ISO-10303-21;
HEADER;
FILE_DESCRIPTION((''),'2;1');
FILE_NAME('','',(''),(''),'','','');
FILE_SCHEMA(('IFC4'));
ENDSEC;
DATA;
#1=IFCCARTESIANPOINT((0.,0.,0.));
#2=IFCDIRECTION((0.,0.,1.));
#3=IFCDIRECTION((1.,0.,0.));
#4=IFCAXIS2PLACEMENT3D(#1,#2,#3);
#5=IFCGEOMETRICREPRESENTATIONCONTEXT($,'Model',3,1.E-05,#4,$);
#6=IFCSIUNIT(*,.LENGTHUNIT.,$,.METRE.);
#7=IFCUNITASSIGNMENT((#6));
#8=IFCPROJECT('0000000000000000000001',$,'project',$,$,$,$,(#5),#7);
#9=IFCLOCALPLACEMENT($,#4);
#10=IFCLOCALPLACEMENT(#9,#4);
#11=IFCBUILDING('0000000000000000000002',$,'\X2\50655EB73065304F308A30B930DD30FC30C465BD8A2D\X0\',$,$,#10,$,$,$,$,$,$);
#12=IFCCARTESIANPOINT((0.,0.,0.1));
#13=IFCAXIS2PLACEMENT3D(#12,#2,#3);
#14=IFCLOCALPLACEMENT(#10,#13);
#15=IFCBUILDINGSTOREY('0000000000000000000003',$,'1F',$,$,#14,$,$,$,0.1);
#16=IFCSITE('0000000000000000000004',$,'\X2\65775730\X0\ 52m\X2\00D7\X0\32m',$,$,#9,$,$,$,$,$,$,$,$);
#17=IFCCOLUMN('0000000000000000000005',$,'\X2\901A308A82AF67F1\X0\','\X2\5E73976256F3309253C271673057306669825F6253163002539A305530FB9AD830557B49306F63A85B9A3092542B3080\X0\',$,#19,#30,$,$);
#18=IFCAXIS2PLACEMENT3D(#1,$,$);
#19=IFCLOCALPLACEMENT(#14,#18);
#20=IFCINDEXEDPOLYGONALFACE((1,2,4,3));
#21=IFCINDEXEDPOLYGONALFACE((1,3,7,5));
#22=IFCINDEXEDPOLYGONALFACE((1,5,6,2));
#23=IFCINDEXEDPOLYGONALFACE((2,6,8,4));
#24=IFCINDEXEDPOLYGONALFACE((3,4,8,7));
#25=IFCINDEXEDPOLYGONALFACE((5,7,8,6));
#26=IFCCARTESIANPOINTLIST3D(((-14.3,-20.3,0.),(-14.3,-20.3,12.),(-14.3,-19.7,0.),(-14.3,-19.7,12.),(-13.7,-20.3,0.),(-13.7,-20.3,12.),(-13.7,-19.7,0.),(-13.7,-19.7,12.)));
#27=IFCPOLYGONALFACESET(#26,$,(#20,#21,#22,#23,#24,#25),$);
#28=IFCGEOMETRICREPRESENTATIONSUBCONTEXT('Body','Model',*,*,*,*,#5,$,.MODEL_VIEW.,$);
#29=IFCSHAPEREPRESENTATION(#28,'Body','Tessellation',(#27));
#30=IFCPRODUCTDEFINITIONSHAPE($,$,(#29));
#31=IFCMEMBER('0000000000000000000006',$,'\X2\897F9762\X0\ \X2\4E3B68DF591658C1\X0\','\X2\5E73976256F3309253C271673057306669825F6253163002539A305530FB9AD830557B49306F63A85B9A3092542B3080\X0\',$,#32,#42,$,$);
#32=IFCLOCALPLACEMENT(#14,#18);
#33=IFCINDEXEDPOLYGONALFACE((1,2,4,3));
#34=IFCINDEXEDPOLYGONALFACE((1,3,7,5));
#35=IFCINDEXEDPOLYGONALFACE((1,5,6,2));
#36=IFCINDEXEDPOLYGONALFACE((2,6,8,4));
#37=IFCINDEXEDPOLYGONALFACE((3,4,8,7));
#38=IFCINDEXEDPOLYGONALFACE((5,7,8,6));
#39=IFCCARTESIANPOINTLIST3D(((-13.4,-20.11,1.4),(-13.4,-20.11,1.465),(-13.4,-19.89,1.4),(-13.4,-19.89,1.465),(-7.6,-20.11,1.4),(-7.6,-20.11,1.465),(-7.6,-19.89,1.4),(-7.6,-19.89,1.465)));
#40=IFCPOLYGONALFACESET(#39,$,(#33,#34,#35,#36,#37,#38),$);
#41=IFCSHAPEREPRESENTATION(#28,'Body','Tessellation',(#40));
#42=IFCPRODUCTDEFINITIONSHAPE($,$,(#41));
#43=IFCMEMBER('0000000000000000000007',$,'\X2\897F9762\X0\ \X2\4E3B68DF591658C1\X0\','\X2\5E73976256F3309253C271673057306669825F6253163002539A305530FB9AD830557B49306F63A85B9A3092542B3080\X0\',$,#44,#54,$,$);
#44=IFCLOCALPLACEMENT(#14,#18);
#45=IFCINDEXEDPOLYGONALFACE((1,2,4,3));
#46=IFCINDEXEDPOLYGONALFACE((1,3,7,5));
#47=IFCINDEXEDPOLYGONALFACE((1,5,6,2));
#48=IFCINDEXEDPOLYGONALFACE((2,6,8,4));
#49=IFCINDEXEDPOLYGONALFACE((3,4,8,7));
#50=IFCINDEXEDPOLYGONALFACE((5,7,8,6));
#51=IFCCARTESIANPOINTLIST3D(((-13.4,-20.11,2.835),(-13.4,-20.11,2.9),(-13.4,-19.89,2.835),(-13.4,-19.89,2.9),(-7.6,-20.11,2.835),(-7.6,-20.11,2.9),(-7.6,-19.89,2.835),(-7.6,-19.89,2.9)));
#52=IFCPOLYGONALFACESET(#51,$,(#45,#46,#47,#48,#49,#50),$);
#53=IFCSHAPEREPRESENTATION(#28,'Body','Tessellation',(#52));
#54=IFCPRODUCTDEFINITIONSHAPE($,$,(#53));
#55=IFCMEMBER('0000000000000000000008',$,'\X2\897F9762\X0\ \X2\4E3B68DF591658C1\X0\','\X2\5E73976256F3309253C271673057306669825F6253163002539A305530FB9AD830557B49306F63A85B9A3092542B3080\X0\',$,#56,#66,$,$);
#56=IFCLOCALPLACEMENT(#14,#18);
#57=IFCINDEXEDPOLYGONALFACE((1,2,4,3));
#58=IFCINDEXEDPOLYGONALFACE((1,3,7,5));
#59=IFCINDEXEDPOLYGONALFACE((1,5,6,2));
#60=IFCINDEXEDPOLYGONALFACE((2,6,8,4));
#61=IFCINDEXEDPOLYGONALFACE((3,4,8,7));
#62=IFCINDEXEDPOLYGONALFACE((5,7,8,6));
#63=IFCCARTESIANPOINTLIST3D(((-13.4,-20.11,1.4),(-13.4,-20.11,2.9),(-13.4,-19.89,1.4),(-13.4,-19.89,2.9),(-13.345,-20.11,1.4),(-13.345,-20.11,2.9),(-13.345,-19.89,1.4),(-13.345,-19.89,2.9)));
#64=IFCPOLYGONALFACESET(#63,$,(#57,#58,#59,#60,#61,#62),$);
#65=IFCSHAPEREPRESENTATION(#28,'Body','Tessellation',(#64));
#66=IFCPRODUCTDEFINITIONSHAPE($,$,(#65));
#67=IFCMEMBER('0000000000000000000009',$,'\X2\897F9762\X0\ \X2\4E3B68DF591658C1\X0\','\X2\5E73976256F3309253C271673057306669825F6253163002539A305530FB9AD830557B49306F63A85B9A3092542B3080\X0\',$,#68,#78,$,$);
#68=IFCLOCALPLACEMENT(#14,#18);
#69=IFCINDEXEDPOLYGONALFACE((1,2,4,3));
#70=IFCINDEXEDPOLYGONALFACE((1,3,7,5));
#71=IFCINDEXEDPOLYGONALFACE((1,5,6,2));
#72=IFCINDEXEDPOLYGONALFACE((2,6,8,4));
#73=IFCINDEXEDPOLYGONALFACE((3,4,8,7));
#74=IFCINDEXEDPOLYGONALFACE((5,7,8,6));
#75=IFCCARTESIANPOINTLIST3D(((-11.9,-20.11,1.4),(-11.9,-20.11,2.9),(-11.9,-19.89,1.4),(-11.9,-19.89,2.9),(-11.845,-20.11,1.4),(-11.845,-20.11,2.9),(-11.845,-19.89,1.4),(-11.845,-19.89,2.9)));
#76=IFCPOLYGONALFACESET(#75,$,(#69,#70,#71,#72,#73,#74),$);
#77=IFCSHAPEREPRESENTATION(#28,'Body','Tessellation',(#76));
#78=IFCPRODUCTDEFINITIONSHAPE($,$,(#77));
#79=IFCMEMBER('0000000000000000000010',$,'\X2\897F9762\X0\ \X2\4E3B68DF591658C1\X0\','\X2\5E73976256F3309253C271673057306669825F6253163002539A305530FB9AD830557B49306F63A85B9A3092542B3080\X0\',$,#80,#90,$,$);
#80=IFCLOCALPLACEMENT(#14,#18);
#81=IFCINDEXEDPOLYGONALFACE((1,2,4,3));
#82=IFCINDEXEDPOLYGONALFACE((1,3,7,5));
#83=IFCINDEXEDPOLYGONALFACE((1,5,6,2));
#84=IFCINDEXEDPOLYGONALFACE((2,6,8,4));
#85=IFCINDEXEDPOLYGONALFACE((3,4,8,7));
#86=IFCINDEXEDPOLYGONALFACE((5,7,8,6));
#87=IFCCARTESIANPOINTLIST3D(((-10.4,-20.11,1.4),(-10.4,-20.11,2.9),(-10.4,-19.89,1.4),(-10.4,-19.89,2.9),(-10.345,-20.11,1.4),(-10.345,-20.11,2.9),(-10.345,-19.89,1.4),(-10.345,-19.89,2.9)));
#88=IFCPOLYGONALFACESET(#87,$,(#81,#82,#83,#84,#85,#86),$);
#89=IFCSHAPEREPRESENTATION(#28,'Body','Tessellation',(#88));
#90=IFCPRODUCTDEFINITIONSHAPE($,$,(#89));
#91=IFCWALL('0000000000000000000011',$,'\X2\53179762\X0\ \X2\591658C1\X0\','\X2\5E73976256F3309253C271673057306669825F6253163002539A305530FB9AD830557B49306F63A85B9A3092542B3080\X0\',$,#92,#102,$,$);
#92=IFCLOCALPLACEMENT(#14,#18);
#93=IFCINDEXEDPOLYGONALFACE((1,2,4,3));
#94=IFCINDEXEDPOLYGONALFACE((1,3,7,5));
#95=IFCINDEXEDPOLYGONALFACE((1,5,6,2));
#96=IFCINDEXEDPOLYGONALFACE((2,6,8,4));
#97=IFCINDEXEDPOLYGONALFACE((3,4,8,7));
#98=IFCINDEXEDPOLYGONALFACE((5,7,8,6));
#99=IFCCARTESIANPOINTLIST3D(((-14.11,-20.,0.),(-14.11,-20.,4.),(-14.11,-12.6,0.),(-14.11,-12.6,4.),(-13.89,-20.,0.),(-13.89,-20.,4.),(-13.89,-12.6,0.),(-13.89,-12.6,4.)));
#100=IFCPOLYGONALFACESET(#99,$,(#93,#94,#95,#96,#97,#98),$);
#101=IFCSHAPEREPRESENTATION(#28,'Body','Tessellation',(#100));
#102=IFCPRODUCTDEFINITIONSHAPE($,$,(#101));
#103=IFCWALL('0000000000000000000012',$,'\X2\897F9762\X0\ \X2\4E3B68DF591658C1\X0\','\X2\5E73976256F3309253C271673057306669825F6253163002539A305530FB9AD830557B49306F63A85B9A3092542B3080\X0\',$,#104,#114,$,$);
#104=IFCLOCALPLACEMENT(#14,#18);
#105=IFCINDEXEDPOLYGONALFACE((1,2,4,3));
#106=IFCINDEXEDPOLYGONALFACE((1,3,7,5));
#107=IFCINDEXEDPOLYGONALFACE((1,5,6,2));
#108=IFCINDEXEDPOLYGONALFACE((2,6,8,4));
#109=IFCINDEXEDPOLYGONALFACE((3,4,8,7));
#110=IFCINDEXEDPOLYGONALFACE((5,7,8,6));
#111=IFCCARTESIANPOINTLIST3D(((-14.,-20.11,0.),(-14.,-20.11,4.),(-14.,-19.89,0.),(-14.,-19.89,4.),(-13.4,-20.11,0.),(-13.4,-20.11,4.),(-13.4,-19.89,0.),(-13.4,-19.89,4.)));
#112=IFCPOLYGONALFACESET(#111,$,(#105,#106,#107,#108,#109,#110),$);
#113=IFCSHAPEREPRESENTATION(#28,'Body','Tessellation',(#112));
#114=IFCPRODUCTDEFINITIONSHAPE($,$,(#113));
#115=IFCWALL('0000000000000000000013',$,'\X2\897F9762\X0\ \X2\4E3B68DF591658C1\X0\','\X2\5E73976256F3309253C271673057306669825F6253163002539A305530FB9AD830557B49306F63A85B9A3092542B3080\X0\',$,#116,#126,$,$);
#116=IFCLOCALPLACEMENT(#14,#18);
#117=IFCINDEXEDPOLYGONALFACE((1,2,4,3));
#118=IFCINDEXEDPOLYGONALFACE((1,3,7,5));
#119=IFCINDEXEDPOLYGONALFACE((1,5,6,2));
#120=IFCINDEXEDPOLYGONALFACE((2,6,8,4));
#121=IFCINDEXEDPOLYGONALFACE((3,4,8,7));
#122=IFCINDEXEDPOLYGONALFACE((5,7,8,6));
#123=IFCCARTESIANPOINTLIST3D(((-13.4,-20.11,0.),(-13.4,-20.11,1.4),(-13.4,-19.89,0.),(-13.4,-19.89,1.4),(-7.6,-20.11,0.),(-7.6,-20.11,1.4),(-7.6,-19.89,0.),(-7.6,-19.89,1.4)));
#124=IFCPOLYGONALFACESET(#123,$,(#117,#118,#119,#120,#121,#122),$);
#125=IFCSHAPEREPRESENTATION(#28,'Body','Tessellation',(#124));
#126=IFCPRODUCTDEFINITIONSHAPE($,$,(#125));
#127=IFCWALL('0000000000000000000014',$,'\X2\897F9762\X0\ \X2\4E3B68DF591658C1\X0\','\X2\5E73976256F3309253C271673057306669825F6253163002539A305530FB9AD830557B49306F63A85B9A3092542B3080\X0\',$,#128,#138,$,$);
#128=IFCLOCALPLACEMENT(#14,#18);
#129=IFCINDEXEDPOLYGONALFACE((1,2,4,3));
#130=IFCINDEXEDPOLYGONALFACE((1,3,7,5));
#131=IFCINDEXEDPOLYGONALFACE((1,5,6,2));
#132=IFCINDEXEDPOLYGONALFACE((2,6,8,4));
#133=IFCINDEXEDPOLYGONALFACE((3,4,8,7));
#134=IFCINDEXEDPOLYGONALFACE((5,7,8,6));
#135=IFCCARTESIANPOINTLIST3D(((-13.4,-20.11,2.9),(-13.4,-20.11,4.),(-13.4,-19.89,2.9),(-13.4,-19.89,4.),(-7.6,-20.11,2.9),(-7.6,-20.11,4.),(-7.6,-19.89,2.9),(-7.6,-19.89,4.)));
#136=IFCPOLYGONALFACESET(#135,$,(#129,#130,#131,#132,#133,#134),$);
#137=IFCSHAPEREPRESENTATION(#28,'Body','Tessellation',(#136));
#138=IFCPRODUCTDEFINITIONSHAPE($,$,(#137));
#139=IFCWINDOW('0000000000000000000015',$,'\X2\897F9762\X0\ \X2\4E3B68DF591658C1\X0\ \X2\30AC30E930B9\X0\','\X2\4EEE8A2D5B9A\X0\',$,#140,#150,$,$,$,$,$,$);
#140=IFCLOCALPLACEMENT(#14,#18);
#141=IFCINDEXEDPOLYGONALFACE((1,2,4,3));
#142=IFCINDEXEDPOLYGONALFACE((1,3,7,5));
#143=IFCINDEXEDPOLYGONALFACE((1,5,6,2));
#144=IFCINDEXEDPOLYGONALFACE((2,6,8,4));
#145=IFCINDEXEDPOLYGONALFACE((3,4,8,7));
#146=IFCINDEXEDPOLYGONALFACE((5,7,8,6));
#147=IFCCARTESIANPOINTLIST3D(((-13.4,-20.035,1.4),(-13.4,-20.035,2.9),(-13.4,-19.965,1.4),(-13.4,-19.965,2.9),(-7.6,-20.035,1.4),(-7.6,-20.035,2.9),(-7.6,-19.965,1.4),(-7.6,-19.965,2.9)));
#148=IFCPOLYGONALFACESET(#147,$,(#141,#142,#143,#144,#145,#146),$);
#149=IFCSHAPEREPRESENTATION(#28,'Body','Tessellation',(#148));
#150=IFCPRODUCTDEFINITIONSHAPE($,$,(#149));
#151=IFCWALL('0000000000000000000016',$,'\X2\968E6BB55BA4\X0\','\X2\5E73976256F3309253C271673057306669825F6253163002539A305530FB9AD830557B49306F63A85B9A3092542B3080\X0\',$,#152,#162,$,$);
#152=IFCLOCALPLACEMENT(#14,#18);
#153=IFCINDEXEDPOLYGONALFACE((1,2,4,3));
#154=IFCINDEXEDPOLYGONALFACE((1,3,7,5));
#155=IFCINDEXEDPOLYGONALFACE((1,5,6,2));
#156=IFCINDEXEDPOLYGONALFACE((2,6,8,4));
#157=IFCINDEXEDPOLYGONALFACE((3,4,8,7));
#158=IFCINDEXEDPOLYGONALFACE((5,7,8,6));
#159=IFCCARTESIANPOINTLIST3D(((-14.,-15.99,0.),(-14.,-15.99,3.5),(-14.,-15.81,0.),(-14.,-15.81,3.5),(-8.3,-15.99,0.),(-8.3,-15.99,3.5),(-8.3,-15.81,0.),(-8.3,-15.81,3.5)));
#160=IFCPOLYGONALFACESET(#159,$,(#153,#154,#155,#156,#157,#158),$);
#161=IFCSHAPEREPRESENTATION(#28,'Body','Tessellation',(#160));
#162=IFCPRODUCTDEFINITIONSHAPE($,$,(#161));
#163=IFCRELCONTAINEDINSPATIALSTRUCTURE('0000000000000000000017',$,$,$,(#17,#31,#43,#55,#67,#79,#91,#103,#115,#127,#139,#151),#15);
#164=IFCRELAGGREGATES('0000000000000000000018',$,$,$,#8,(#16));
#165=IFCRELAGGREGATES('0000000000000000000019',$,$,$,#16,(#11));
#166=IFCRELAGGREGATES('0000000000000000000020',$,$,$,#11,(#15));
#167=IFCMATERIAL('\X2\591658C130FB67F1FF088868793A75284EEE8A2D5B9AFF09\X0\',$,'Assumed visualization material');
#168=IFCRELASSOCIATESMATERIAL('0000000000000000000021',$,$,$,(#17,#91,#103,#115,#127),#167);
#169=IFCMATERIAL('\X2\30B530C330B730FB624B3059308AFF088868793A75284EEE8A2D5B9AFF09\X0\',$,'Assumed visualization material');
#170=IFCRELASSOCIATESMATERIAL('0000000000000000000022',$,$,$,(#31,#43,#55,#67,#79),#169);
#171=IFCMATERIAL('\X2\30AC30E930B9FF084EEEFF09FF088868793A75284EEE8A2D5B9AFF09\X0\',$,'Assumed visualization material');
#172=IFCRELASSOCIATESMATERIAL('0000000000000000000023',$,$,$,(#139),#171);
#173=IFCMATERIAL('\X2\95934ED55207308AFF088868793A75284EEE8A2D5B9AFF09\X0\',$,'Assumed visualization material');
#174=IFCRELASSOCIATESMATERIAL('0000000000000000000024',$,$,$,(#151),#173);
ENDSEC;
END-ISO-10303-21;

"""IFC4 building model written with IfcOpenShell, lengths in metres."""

from ifc_helpers import new_model, si_unit, frame, origin_with_axes, place, context, subcontext, project, spatial, rectangle, extrude, material, element, save


model = new_model("IFC4")

# Units and contexts
model_context = context("Model", 3, precision=1e-05, world=origin_with_axes())
body_context = subcontext(model_context, "Body", "Model", "MODEL_VIEW")
ifc_project = project(units=[si_unit("LENGTHUNIT", "METRE")], contexts=[model_context])

# Site, building, storey
site_placement = place(None, origin_with_axes())
site = spatial("IfcSite", under=ifc_project, at=site_placement, Name="敷地 52m×32m")
building_placement = place(site_placement, origin_with_axes())
building = spatial("IfcBuilding", under=site, at=building_placement, Name="健康づくりスポーツ施設")
storey_placement = place(building_placement, frame((0.0, 0.0, 0.1), z_axis=(0.0, 0.0, 1.0), x_axis=(1.0, 0.0, 0.0)))
storey = spatial("IfcBuildingStorey", under=building, at=storey_placement, Name="1F", Elevation=0.1)

# Column
ifc_material_1 = material(Name="外壁・柱（表示用仮設定）", Category="Assumed visualization material")
column_placement = place(storey_placement, frame((-14.0, -20.0, 0.0), z_axis=(0.0, 0.0, 1.0), x_axis=(1.0, 0.0, 0.0)))
element("IfcColumn", 1, at=column_placement, inside=storey, material=ifc_material_1, Name="通り芯柱", Description="平面図を参照して概形化。厚さ・高さ等は推定を含む", context=body_context, shape_type="SweptSolid", body=[
    extrude(rectangle(XDim=0.6, YDim=0.6), origin_with_axes(), (0.0, 0.0, 1.0), 12.0),
])

# Members
ifc_material_2 = material(Name="サッシ・手すり（表示用仮設定）", Category="Assumed visualization material")
for number, where, z_axis, x_axis, name in (
    (2, (-10.5, -20.0, 1.4), (0.0, 0.0, 1.0), (1.0, 0.0, 0.0), "西面 主棟外壁"),
    (3, (-10.5, -20.0, 2.835), (0.0, 0.0, 1.0), (1.0, 0.0, 0.0), "西面 主棟外壁"),
):
    element("IfcMember", number, at=place(storey_placement, frame(where, z_axis=z_axis, x_axis=x_axis)), inside=storey, material=ifc_material_2, Name=name, Description="平面図を参照して概形化。厚さ・高さ等は推定を含む", context=body_context, shape_type="SweptSolid", body=[
        extrude(rectangle(XDim=5.8, YDim=0.22), origin_with_axes(), (0.0, 0.0, 1.0), 0.065),
    ])
member_placement = place(storey_placement, frame((-13.3725, -20.0, 1.4), z_axis=(0.0, 0.0, 1.0), x_axis=(1.0, 0.0, 0.0)))
element("IfcMember", 4, at=member_placement, inside=storey, material=ifc_material_2, Name="西面 主棟外壁", Description="平面図を参照して概形化。厚さ・高さ等は推定を含む", context=body_context, shape_type="SweptSolid", body=[
    extrude(rectangle(XDim=0.055, YDim=0.22), origin_with_axes(), (0.0, 0.0, 1.0), 1.5),
])
for number, where, z_axis, x_axis, name in (
    (5, (-11.8725, -20.0, 1.4), (0.0, 0.0, 1.0), (1.0, 0.0, 0.0), "西面 主棟外壁"),
    (6, (-10.3725, -20.0, 1.4), (0.0, 0.0, 1.0), (1.0, 0.0, 0.0), "西面 主棟外壁"),
):
    element("IfcMember", number, at=place(storey_placement, frame(where, z_axis=z_axis, x_axis=x_axis)), inside=storey, material=ifc_material_2, Name=name, Description="平面図を参照して概形化。厚さ・高さ等は推定を含む", context=body_context, shape_type="SweptSolid", body=[
        extrude(rectangle(XDim=0.055, YDim=0.22), origin_with_axes(), (0.0, 0.0, 1.0), 1.5),
    ])

# Walls
wall_1_placement = place(storey_placement, frame((-14.0, -16.3, 0.0), z_axis=(0.0, 0.0, 1.0), x_axis=(1.0, 0.0, 0.0)))
element("IfcWall", 7, at=wall_1_placement, inside=storey, material=ifc_material_1, Name="北面 外壁", Description="平面図を参照して概形化。厚さ・高さ等は推定を含む", context=body_context, shape_type="SweptSolid", body=[
    extrude(rectangle(XDim=0.22, YDim=7.4), origin_with_axes(), (0.0, 0.0, 1.0), 4.0),
])
wall_2_placement = place(storey_placement, frame((-13.7, -20.0, 0.0), z_axis=(0.0, 0.0, 1.0), x_axis=(1.0, 0.0, 0.0)))
element("IfcWall", 8, at=wall_2_placement, inside=storey, material=ifc_material_1, Name="西面 主棟外壁", Description="平面図を参照して概形化。厚さ・高さ等は推定を含む", context=body_context, shape_type="SweptSolid", body=[
    extrude(rectangle(XDim=0.6, YDim=0.22), origin_with_axes(), (0.0, 0.0, 1.0), 4.0),
])
wall_3_placement = place(storey_placement, frame((-10.5, -20.0, 0.0), z_axis=(0.0, 0.0, 1.0), x_axis=(1.0, 0.0, 0.0)))
element("IfcWall", 9, at=wall_3_placement, inside=storey, material=ifc_material_1, Name="西面 主棟外壁", Description="平面図を参照して概形化。厚さ・高さ等は推定を含む", context=body_context, shape_type="SweptSolid", body=[
    extrude(rectangle(XDim=5.8, YDim=0.22), origin_with_axes(), (0.0, 0.0, 1.0), 1.4),
])
wall_4_placement = place(storey_placement, frame((-10.5, -20.0, 2.9), z_axis=(0.0, 0.0, 1.0), x_axis=(1.0, 0.0, 0.0)))
element("IfcWall", 10, at=wall_4_placement, inside=storey, material=ifc_material_1, Name="西面 主棟外壁", Description="平面図を参照して概形化。厚さ・高さ等は推定を含む", context=body_context, shape_type="SweptSolid", body=[
    extrude(rectangle(XDim=5.8, YDim=0.22), origin_with_axes(), (0.0, 0.0, 1.0), 1.1),
])

# Window
ifc_material_3 = material(Name="ガラス（仮）（表示用仮設定）", Category="Assumed visualization material")
window_placement = place(storey_placement, frame((-10.5, -20.0, 1.4), z_axis=(0.0, 0.0, 1.0), x_axis=(1.0, 0.0, 0.0)))
element("IfcWindow", 11, at=window_placement, inside=storey, material=ifc_material_3, Name="西面 主棟外壁 ガラス", Description="仮設定", context=body_context, shape_type="SweptSolid", body=[
    extrude(rectangle(XDim=5.8, YDim=0.07), origin_with_axes(), (0.0, 0.0, 1.0), 1.5),
])

# Wall
ifc_material_4 = material(Name="間仕切り（表示用仮設定）", Category="Assumed visualization material")
wall_5_placement = place(storey_placement, frame((-11.15, -15.9, 0.0), z_axis=(0.0, 0.0, 1.0), x_axis=(1.0, 0.0, 0.0)))
element("IfcWall", 12, at=wall_5_placement, inside=storey, material=ifc_material_4, Name="階段室", Description="平面図を参照して概形化。厚さ・高さ等は推定を含む", context=body_context, shape_type="SweptSolid", body=[
    extrude(rectangle(XDim=5.7, YDim=0.18), origin_with_axes(), (0.0, 0.0, 1.0), 3.5),
])

save(model, "model.ifc")
